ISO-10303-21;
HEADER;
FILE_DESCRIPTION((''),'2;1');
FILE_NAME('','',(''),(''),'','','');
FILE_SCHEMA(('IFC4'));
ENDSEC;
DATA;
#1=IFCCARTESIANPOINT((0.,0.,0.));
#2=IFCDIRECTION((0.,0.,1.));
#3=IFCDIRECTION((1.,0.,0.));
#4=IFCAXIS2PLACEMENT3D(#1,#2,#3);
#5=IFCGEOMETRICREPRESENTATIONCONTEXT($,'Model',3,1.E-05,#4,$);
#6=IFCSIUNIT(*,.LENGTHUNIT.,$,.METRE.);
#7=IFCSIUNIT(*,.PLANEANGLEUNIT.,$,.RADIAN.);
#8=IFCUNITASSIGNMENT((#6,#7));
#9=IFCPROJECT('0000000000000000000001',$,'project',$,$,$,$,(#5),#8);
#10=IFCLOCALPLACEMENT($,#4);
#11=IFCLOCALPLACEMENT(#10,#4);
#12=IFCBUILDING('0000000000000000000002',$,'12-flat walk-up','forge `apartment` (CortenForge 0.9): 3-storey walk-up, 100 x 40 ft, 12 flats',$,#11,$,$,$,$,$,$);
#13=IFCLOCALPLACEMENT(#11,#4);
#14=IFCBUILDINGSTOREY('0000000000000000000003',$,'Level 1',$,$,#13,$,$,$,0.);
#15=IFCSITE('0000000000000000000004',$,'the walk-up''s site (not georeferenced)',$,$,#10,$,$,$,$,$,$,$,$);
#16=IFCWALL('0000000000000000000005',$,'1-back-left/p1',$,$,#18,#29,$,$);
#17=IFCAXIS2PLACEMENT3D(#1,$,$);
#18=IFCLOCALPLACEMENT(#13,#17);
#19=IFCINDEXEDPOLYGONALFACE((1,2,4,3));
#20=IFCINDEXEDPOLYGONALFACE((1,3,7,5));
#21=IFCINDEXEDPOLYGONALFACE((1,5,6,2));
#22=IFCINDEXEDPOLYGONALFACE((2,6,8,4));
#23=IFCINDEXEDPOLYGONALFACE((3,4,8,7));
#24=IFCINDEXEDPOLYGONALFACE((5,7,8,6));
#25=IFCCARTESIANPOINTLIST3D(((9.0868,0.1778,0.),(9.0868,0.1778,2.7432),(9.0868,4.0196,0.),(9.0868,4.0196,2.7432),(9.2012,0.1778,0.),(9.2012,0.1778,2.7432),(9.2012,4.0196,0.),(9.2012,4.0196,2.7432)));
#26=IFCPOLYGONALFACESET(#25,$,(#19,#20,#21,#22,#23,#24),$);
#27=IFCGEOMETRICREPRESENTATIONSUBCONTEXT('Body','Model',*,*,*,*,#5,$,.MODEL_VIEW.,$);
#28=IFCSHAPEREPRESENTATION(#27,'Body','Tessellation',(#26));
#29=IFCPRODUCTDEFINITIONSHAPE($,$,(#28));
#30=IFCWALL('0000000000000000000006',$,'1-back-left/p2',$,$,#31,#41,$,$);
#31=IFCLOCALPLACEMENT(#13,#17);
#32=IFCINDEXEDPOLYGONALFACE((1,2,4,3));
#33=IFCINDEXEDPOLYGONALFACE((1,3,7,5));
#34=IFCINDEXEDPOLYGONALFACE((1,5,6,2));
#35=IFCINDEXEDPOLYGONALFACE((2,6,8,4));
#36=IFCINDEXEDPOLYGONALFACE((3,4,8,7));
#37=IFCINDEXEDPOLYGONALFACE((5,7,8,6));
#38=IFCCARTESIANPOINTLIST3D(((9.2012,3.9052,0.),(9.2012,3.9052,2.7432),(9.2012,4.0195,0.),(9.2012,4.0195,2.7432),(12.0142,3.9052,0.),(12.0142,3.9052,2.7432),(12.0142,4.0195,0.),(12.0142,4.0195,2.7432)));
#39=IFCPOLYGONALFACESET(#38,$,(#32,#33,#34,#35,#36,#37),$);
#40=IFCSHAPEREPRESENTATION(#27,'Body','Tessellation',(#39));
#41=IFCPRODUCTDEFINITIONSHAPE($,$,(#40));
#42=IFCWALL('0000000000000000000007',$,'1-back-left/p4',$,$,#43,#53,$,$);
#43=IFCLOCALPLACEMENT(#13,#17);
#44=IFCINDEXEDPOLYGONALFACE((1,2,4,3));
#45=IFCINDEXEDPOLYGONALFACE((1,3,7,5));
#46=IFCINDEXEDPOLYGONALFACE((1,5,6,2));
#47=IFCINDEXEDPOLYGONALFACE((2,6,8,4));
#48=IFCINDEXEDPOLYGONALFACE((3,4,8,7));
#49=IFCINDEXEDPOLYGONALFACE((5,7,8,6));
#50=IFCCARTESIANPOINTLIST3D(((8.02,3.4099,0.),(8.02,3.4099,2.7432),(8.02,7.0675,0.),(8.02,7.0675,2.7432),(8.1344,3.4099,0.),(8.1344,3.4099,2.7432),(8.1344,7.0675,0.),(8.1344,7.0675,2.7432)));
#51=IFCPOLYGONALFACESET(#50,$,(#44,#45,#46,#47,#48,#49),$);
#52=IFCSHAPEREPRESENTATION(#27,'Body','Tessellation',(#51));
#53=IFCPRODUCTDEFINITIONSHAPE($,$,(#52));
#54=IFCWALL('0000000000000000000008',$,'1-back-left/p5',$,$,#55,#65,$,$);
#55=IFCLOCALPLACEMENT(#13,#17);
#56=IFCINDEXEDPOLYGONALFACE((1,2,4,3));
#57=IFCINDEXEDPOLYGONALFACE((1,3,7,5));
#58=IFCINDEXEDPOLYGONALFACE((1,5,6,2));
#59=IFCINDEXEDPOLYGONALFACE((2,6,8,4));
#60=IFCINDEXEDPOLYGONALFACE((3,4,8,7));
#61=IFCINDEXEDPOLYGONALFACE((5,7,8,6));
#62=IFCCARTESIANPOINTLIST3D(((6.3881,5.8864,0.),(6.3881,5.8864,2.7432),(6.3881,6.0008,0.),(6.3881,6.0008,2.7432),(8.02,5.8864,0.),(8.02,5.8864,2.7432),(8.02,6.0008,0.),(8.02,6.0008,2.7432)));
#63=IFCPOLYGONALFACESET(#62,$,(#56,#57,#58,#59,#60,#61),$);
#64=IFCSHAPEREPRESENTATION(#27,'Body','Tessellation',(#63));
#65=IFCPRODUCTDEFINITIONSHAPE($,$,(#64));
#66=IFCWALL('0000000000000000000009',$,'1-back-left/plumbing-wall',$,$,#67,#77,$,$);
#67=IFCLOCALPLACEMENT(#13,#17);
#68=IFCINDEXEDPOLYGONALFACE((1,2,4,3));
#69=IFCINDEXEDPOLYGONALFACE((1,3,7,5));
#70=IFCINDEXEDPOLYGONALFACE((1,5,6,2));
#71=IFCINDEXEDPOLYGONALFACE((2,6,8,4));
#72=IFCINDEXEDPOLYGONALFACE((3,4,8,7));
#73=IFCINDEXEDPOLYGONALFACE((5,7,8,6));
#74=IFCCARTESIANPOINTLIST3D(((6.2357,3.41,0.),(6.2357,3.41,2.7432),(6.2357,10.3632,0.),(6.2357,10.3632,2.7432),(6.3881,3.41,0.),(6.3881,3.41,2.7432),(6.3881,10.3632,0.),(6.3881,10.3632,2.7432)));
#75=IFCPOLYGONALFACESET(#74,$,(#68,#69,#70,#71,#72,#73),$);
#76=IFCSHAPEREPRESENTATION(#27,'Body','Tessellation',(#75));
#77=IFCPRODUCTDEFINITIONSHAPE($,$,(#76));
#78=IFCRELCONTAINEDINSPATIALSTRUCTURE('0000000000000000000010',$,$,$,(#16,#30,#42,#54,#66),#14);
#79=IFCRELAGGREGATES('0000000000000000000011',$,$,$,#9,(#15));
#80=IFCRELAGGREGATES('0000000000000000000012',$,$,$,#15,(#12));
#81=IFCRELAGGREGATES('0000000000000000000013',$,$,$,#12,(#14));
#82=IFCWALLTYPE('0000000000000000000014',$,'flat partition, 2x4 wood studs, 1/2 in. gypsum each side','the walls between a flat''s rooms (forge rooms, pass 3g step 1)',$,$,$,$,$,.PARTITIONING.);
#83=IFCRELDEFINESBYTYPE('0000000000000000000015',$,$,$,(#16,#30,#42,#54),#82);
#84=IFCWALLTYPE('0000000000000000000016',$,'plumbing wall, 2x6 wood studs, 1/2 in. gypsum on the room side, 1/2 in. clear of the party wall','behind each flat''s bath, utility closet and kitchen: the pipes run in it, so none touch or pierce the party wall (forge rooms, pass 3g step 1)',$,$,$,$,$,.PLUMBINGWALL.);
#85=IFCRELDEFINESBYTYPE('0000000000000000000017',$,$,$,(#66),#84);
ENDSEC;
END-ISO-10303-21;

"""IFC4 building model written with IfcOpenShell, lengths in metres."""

from ifc_helpers import new_model, si_unit, frame, frame_2d, origin, origin_with_axes, place, context, subcontext, project, spatial, rectangle, extrude, type_object, element, save


model = new_model("IFC4")

# Units and contexts
model_context = context("Model", 3, precision=1e-05, world=origin_with_axes())
body_context = subcontext(model_context, "Body", "Model", "MODEL_VIEW")
ifc_project = project(units=[si_unit("LENGTHUNIT", "METRE"), si_unit("PLANEANGLEUNIT", "RADIAN")], contexts=[model_context])

# Site, building, storey
site_placement = place(None, origin_with_axes())
site = spatial("IfcSite", under=ifc_project, at=site_placement, Name="the walk-up's site (not georeferenced)")
building_placement = place(site_placement, origin_with_axes())
building = spatial("IfcBuilding", under=site, at=building_placement, Name="12-flat walk-up", Description="forge `apartment` (CortenForge 0.9): 3-storey walk-up, 100 x 40 ft, 12 flats")
storey_placement = place(building_placement, origin_with_axes())
storey = spatial("IfcBuildingStorey", under=building, at=storey_placement, Name="Level 1", Elevation=0.0)

# Walls
wall_type_1 = type_object("IfcWallType", Name="flat partition, 2x4 wood studs, 1/2 in. gypsum each side", Description="the walls between a flat's rooms (forge rooms, pass 3g step 1)", PredefinedType="PARTITIONING")
wall_1_placement = place(storey_placement, frame((9.0869, 0.1778, 0.0), z_axis=(0.0, 0.0, 1.0), x_axis=(1.0, 0.0, 0.0)))
element("IfcWall", 1, at=wall_1_placement, inside=storey, type_object=wall_type_1, Name="1-back-left/p1", context=body_context, shape_type="SweptSolid", body=[
    extrude(rectangle(XDim=0.1143, YDim=3.8417, at=frame_2d((0.0572, 1.9209))), origin(), (0.0, 0.0, 1.0), 2.7432),
])
wall_2_placement = place(storey_placement, frame((9.2012, 3.9052, 0.0), z_axis=(0.0, 0.0, 1.0), x_axis=(1.0, 0.0, 0.0)))
element("IfcWall", 2, at=wall_2_placement, inside=storey, type_object=wall_type_1, Name="1-back-left/p2", context=body_context, shape_type="SweptSolid", body=[
    extrude(rectangle(XDim=2.8131, YDim=0.1143, at=frame_2d((1.4065, 0.0571))), origin(), (0.0, 0.0, 1.0), 2.7432),
])
wall_3_placement = place(storey_placement, frame((8.02, 3.4099, 0.0), z_axis=(0.0, 0.0, 1.0), x_axis=(1.0, 0.0, 0.0)))
element("IfcWall", 3, at=wall_3_placement, inside=storey, type_object=wall_type_1, Name="1-back-left/p4", context=body_context, shape_type="SweptSolid", body=[
    extrude(rectangle(XDim=0.1143, YDim=3.6576, at=frame_2d((0.0572, 1.8288))), origin(), (0.0, 0.0, 1.0), 2.7432),
])
wall_4_placement = place(storey_placement, frame((6.3881, 5.8864, 0.0), z_axis=(0.0, 0.0, 1.0), x_axis=(1.0, 0.0, 0.0)))
element("IfcWall", 4, at=wall_4_placement, inside=storey, type_object=wall_type_1, Name="1-back-left/p5", context=body_context, shape_type="SweptSolid", body=[
    extrude(rectangle(XDim=1.6319, YDim=0.1143, at=frame_2d((0.816, 0.0572))), origin(), (0.0, 0.0, 1.0), 2.7432),
])
wall_type_2 = type_object("IfcWallType", Name="plumbing wall, 2x6 wood studs, 1/2 in. gypsum on the room side, 1/2 in. clear of the party wall", Description="behind each flat's bath, utility closet and kitchen: the pipes run in it, so none touch or pierce the party wall (forge rooms, pass 3g step 1)", PredefinedType="PLUMBINGWALL")
wall_5_placement = place(storey_placement, frame((6.2357, 3.41, 0.0), z_axis=(0.0, 0.0, 1.0), x_axis=(1.0, 0.0, 0.0)))
element("IfcWall", 5, at=wall_5_placement, inside=storey, type_object=wall_type_2, Name="1-back-left/plumbing-wall", context=body_context, shape_type="SweptSolid", body=[
    extrude(rectangle(XDim=0.1524, YDim=6.9533, at=frame_2d((0.0762, 3.4766))), origin(), (0.0, 0.0, 1.0), 2.7432),
])

save(model, "model.ifc")
